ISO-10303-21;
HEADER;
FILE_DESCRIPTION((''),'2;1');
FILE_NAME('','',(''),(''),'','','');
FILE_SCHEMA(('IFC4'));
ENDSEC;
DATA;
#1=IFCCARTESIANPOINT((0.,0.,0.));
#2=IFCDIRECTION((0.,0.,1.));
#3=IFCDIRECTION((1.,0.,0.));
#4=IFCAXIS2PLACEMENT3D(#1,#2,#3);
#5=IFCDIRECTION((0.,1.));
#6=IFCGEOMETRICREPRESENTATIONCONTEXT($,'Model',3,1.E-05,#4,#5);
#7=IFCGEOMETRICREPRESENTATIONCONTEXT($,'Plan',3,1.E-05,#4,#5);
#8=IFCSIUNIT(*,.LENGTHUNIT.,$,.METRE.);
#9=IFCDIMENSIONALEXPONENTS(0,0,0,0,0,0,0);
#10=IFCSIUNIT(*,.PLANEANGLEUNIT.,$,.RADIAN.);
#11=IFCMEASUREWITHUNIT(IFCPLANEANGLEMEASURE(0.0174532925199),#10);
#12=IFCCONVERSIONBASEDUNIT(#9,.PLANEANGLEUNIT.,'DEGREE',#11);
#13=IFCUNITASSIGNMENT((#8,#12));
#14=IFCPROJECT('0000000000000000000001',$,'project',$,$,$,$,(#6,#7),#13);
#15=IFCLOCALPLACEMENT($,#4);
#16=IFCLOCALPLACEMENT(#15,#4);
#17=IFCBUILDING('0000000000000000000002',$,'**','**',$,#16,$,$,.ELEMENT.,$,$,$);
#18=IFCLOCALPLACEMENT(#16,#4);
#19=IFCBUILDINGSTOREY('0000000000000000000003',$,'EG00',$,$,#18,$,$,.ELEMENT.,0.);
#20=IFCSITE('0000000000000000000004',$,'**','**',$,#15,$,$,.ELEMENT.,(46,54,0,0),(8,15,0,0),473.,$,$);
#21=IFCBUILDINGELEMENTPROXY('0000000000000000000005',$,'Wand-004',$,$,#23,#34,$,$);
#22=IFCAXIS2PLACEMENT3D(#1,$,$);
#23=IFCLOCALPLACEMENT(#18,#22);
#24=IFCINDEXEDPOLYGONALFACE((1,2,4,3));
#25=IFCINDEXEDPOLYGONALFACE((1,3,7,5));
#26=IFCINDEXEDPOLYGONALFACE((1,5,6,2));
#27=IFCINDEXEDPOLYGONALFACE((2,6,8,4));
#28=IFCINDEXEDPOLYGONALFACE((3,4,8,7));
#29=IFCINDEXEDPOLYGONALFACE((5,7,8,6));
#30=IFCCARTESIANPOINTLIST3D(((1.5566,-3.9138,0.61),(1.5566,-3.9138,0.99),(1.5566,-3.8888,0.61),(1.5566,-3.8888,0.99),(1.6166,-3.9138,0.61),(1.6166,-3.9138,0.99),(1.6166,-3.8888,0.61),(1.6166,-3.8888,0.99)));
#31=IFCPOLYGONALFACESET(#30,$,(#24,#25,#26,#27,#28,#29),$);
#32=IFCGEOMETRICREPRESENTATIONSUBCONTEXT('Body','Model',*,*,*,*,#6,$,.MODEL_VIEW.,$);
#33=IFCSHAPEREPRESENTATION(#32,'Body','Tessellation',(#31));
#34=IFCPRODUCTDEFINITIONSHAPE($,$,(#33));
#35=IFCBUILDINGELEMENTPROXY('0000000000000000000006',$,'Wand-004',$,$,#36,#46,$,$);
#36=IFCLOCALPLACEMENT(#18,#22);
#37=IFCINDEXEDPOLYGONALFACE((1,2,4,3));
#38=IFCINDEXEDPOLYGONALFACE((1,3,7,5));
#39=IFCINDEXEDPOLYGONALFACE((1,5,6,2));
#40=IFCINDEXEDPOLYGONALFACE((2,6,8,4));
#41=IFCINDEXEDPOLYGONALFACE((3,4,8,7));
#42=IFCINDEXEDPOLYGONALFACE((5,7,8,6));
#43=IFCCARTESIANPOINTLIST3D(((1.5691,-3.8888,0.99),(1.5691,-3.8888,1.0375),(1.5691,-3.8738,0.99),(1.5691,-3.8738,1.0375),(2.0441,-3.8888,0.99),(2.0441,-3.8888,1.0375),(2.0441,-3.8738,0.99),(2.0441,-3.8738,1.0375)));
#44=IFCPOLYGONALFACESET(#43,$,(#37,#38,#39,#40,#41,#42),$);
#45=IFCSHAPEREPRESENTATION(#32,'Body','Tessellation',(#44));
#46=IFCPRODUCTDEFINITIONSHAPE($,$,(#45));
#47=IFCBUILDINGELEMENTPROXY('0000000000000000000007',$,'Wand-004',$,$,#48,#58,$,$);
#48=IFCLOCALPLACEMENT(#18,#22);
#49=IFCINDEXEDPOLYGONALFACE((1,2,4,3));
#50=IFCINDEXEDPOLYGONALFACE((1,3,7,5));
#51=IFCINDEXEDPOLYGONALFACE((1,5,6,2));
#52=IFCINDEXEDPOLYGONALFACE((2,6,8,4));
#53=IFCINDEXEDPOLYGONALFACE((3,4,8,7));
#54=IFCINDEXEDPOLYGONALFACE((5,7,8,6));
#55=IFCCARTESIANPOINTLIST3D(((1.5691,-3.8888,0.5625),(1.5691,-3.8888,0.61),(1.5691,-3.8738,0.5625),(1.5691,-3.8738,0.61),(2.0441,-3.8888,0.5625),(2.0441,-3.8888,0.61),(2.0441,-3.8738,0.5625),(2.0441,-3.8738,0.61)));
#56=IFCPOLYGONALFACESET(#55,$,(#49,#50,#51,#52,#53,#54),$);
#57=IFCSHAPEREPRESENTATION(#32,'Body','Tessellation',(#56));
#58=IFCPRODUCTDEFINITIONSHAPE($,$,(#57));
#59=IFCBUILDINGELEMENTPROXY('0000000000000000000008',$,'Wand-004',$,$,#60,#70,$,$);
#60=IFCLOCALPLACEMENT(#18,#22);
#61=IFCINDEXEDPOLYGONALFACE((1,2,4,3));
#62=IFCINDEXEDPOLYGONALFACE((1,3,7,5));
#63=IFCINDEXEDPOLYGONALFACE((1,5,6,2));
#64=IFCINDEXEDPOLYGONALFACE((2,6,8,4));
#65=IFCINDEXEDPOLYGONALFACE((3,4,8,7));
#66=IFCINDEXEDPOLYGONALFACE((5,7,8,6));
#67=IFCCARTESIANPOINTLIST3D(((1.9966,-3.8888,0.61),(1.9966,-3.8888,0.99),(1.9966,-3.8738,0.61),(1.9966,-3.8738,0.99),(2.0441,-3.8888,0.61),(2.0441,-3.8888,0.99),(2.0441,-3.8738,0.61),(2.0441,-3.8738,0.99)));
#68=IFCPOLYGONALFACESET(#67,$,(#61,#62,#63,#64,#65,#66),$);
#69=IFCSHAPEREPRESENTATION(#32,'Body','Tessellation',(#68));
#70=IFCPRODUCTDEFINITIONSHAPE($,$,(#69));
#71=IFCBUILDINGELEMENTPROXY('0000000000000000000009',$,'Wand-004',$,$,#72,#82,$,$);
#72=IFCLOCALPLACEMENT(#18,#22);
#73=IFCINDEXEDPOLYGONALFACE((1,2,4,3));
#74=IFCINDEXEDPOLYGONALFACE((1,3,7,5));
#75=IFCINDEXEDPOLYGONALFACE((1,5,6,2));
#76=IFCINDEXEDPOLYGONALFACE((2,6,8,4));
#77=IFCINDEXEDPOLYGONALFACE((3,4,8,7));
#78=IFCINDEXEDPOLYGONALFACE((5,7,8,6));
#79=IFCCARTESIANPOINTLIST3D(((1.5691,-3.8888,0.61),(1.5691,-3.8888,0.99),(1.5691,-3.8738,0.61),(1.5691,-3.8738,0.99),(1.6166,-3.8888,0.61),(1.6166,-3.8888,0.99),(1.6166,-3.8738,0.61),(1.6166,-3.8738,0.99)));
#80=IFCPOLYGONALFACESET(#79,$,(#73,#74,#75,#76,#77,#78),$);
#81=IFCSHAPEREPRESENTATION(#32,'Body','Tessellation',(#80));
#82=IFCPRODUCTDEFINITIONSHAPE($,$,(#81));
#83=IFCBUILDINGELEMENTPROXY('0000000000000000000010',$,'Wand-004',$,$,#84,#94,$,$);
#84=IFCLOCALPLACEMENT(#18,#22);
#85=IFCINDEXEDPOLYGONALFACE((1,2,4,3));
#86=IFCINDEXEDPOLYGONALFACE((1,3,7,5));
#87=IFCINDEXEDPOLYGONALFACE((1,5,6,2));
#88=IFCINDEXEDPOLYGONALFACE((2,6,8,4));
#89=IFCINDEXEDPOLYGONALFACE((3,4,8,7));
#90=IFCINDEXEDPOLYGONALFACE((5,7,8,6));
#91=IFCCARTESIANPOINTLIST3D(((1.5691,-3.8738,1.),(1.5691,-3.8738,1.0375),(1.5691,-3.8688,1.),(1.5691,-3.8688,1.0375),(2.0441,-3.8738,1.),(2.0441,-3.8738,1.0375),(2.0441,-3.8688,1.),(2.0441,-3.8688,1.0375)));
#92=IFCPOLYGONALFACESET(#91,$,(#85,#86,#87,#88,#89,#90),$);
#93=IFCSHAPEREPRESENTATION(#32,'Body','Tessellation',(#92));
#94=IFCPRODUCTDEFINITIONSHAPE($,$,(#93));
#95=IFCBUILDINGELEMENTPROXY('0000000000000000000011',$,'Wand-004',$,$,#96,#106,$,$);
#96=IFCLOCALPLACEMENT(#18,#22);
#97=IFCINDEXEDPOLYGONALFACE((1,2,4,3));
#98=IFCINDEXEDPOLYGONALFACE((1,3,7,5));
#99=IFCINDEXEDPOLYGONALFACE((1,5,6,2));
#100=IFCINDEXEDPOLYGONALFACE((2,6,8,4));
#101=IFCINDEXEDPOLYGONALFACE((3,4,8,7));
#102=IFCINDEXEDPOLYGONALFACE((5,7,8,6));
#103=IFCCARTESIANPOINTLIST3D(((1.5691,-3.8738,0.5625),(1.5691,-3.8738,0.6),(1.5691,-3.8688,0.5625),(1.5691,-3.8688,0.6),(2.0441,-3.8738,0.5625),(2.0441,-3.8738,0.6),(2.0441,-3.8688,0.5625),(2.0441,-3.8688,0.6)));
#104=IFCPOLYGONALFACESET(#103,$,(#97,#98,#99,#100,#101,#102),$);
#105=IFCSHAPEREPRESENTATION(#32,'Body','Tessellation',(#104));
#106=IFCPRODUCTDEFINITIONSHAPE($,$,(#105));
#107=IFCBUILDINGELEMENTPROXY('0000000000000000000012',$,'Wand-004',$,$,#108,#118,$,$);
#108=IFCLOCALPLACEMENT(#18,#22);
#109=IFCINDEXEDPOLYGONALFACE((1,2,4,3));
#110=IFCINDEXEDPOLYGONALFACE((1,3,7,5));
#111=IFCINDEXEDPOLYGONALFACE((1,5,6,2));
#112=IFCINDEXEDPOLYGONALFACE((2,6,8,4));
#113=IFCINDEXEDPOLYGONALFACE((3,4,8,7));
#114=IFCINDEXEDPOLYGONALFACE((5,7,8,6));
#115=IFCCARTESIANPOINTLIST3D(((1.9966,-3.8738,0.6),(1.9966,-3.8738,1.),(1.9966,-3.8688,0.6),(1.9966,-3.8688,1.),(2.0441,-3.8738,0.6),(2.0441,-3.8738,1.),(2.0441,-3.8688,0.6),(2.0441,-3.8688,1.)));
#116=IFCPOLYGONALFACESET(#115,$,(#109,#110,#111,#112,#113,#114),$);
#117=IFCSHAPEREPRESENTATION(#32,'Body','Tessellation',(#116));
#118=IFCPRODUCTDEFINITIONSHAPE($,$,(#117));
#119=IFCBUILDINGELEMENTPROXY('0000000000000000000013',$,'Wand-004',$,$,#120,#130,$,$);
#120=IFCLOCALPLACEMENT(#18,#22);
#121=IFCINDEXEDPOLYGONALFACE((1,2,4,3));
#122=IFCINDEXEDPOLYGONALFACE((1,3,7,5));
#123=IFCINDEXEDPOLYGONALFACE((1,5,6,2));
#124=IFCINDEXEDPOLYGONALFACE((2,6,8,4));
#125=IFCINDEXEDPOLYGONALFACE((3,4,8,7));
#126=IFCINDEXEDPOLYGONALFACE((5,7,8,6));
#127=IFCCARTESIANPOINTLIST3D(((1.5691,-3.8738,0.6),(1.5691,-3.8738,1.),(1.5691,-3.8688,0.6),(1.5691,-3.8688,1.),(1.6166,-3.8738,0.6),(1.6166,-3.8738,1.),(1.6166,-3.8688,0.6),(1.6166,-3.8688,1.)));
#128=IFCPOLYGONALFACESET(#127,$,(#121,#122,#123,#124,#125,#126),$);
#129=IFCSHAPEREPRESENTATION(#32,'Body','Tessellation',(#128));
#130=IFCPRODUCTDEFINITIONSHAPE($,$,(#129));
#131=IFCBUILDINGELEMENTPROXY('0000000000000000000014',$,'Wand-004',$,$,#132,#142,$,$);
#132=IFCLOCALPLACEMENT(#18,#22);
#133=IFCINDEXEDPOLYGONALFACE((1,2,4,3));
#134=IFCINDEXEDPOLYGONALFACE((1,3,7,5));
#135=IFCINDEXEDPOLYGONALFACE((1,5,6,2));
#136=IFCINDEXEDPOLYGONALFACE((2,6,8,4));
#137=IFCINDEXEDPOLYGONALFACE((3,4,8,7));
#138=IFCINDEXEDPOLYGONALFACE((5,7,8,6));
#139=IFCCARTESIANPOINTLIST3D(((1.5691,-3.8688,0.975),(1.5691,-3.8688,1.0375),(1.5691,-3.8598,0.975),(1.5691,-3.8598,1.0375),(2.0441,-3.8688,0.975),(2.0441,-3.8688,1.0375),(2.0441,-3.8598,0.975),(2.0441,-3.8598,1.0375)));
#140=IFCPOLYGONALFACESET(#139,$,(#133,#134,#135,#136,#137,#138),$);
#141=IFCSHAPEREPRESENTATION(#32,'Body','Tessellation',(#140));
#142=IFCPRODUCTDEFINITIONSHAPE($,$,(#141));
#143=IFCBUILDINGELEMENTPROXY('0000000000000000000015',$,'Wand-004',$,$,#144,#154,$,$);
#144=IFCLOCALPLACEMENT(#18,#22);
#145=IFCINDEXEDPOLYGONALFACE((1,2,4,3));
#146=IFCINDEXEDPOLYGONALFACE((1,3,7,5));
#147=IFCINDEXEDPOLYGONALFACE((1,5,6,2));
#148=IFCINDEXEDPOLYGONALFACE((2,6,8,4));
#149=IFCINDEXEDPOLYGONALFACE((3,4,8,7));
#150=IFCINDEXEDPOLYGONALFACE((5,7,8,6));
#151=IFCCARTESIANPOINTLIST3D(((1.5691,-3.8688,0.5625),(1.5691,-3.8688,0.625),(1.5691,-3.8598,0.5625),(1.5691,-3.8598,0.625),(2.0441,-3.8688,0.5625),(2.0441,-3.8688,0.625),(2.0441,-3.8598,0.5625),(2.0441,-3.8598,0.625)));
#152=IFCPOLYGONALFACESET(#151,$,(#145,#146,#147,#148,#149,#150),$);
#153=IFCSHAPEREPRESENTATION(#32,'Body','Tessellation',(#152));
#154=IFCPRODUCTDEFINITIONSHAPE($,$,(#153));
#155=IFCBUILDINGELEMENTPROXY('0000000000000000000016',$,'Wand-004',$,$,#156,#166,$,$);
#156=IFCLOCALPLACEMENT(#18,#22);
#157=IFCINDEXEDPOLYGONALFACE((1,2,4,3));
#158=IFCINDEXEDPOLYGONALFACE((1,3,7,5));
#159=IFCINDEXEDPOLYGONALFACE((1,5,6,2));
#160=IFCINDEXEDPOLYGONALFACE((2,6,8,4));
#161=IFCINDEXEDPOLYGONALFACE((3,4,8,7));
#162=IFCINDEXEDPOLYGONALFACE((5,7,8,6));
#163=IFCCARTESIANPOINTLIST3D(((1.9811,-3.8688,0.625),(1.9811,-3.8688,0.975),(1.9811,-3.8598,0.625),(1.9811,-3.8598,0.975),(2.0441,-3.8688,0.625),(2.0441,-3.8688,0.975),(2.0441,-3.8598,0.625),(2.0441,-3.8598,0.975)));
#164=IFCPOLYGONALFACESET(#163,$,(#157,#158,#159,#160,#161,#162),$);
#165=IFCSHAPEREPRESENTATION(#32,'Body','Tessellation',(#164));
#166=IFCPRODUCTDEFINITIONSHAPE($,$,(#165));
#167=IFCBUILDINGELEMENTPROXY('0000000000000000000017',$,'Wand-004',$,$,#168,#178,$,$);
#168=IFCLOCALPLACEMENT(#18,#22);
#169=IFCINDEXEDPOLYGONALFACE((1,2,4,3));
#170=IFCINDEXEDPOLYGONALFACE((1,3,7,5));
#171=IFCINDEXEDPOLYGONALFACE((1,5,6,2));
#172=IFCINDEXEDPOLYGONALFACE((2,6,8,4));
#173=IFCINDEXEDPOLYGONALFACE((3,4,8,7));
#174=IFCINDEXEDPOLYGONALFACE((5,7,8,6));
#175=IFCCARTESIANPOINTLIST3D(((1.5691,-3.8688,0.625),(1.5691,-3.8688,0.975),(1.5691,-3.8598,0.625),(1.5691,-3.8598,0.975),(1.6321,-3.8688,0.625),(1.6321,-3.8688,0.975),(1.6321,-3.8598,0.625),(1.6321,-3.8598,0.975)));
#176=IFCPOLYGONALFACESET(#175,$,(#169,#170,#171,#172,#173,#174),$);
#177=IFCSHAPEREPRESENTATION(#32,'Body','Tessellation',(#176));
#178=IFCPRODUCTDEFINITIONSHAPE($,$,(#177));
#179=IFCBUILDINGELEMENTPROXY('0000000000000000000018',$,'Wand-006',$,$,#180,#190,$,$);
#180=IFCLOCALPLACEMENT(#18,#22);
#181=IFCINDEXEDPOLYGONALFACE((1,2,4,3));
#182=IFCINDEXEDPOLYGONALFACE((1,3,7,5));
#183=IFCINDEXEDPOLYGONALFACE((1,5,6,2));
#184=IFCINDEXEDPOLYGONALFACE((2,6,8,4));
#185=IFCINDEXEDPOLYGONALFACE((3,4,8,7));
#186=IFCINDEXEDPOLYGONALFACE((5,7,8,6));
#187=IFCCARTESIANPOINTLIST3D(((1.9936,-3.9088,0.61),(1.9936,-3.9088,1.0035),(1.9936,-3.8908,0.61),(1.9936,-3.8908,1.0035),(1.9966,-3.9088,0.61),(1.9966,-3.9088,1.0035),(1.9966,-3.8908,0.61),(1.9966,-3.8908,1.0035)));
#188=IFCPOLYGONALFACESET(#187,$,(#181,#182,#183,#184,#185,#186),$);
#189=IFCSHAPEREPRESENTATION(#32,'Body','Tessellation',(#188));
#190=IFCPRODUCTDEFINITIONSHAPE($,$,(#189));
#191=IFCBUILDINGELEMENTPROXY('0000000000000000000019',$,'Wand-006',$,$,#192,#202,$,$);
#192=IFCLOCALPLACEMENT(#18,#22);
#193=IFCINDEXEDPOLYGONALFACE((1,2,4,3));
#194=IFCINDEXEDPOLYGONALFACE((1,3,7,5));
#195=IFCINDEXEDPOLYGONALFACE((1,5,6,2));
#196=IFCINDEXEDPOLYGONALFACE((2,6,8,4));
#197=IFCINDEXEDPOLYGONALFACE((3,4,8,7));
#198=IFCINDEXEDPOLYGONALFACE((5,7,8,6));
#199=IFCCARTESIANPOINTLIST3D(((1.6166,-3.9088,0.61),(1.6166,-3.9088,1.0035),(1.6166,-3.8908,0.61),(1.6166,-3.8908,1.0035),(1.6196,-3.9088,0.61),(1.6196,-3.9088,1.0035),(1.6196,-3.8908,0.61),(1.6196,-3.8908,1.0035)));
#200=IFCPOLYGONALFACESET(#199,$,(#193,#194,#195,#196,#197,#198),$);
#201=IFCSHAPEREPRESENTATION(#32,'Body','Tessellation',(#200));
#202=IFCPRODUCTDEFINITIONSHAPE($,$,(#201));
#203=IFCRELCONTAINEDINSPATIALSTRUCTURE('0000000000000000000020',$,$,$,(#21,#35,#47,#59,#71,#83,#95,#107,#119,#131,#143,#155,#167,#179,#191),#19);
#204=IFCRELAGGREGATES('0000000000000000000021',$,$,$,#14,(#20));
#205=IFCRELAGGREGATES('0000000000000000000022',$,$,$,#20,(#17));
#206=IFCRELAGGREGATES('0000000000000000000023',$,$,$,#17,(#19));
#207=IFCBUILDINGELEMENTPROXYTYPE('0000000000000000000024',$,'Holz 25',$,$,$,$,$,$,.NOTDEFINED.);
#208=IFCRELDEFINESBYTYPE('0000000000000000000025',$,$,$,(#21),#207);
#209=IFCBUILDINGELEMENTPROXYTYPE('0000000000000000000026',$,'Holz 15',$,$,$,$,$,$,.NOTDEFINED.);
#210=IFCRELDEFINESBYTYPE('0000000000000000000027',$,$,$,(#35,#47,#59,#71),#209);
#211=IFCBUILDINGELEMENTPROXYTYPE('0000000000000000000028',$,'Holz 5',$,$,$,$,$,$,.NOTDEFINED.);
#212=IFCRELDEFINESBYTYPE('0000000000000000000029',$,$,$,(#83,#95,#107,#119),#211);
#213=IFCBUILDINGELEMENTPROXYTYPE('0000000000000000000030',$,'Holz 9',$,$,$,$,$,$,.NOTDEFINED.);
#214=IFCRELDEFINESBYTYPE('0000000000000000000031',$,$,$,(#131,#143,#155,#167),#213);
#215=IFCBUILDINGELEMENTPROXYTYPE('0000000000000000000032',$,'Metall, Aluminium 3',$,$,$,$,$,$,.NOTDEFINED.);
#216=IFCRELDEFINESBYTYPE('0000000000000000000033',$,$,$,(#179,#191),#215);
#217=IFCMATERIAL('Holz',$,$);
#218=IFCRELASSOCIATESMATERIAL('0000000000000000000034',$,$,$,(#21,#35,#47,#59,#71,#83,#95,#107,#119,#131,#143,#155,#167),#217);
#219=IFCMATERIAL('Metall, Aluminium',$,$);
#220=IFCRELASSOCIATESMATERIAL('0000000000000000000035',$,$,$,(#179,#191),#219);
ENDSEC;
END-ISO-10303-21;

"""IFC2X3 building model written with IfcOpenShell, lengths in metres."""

from ifc_helpers import new_model, entity, si_unit, converted_unit, direction, frame, origin_with_axes, place, context, subcontext, project, spatial, polyline, outline, extrude, material, type_object, element, save


model = new_model("IFC2X3")

# Units and contexts
model_context = context("Model", 3, precision=1e-05, world=origin_with_axes(), true_north=direction((0.0, 1.0)))
plan_context = context("Plan", 3, precision=1e-05, world=origin_with_axes(), true_north=direction((0.0, 1.0)))
body_context = subcontext(model_context, "Body", "Model", "MODEL_VIEW")
ifc_project = project(units=[si_unit("LENGTHUNIT", "METRE"), converted_unit("PLANEANGLEUNIT", "DEGREE", entity("IfcPlaneAngleMeasure", 0.0174532925199), si_unit("PLANEANGLEUNIT", "RADIAN"), dimensions=[0, 0, 0, 0, 0, 0, 0])], contexts=[model_context, plan_context])

# Site, building, storey
site_placement = place(None, origin_with_axes())
site = spatial("IfcSite", under=ifc_project, at=site_placement, Name="**", Description="**", CompositionType="ELEMENT", RefLatitude=(46, 54, 0, 0), RefLongitude=(8, 15, 0, 0), RefElevation=473.0)
building_placement = place(site_placement, origin_with_axes())
building = spatial("IfcBuilding", under=site, at=building_placement, Name="**", Description="**", CompositionType="ELEMENT")
storey_placement = place(building_placement, origin_with_axes())
storey = spatial("IfcBuildingStorey", under=building, at=storey_placement, Name="EG00", CompositionType="ELEMENT", Elevation=0.0)

# Shared definitions
ifc_material_1 = material(Name="Holz")

# Building element proxies
building_element_proxy_type_1 = type_object("IfcBuildingElementProxyType", Name="Holz 25", PredefinedType="NOTDEFINED")
for number, where, z_axis, x_axis, name in (
    (1, (1.5566, -3.9138, 0.61), (0.0, 0.0, 1.0), (1.0, 0.0, 0.0), "Wand-004"),
):
    element("IfcBuildingElementProxy", number, at=place(storey_placement, frame(where, z_axis=z_axis, x_axis=x_axis)), inside=storey, type_object=building_element_proxy_type_1, material=ifc_material_1, Name=name, context=body_context, shape_type="SweptSolid", body=[
        extrude(outline(polyline([(0.0, 0.0), (0.06, 0.0), (0.06, 0.025), (0.0, 0.025), (0.0, 0.0)])), origin_with_axes(), (0.0, 0.0, 1.0), 0.38),
    ])
building_element_proxy_type_2 = type_object("IfcBuildingElementProxyType", Name="Holz 15", PredefinedType="NOTDEFINED")
for number, where, z_axis, x_axis, name in (
    (2, (2.0441, -3.8738, 0.99), (0.0, 0.0, 1.0), (-1.0, 0.0, 0.0), "Wand-004"),
    (3, (2.0441, -3.8738, 0.5625), (0.0, 0.0, 1.0), (-1.0, 0.0, 0.0), "Wand-004"),
):
    element("IfcBuildingElementProxy", number, at=place(storey_placement, frame(where, z_axis=z_axis, x_axis=x_axis)), inside=storey, type_object=building_element_proxy_type_2, material=ifc_material_1, Name=name, context=body_context, shape_type="SweptSolid", body=[
        extrude(outline(polyline([(0.0, 0.0), (0.475, 0.0), (0.475, 0.015), (0.0, 0.015), (0.0, 0.0)])), origin_with_axes(), (0.0, 0.0, 1.0), 0.0475),
    ])
for number, where, z_axis, x_axis, name in (
    (4, (1.9966, -3.8888, 0.61), (0.0, 0.0, 1.0), (1.0, 0.0, 0.0), "Wand-004"),
    (5, (1.5691, -3.8888, 0.61), (0.0, 0.0, 1.0), (1.0, 0.0, 0.0), "Wand-004"),
):
    element("IfcBuildingElementProxy", number, at=place(storey_placement, frame(where, z_axis=z_axis, x_axis=x_axis)), inside=storey, type_object=building_element_proxy_type_2, material=ifc_material_1, Name=name, context=body_context, shape_type="SweptSolid", body=[
        extrude(outline(polyline([(0.0, 0.0), (0.0475, 0.0), (0.0475, 0.015), (0.0, 0.015), (0.0, 0.0)])), origin_with_axes(), (0.0, 0.0, 1.0), 0.38),
    ])
building_element_proxy_type_3 = type_object("IfcBuildingElementProxyType", Name="Holz 5", PredefinedType="NOTDEFINED")
for number, where, z_axis, x_axis, name in (
    (6, (2.0441, -3.8738, 1.0), (0.0, 0.0, 1.0), (-1.0, 0.0, 0.0), "Wand-004"),
    (7, (2.0441, -3.8738, 0.5625), (0.0, 0.0, 1.0), (-1.0, 0.0, 0.0), "Wand-004"),
):
    element("IfcBuildingElementProxy", number, at=place(storey_placement, frame(where, z_axis=z_axis, x_axis=x_axis)), inside=storey, type_object=building_element_proxy_type_3, material=ifc_material_1, Name=name, context=body_context, shape_type="SweptSolid", body=[
        extrude(outline(polyline([(0.0, -0.005), (0.475, -0.005), (0.475, 0.0), (0.0, 0.0), (0.0, -0.005)])), origin_with_axes(), (0.0, 0.0, 1.0), 0.0375),
    ])
for number, where, z_axis, x_axis, name in (
    (8, (1.9966, -3.8738, 0.6), (0.0, 0.0, 1.0), (1.0, 0.0, 0.0), "Wand-004"),
    (9, (1.5691, -3.8738, 0.6), (0.0, 0.0, 1.0), (1.0, 0.0, 0.0), "Wand-004"),
):
    element("IfcBuildingElementProxy", number, at=place(storey_placement, frame(where, z_axis=z_axis, x_axis=x_axis)), inside=storey, type_object=building_element_proxy_type_3, material=ifc_material_1, Name=name, context=body_context, shape_type="SweptSolid", body=[
        extrude(outline(polyline([(0.0, 0.0), (0.0475, 0.0), (0.0475, 0.005), (0.0, 0.005), (0.0, 0.0)])), origin_with_axes(), (0.0, 0.0, 1.0), 0.4),
    ])
building_element_proxy_type_4 = type_object("IfcBuildingElementProxyType", Name="Holz 9", PredefinedType="NOTDEFINED")
for number, where, z_axis, x_axis, name in (
    (10, (2.0441, -3.8688, 0.975), (0.0, 0.0, 1.0), (-1.0, 0.0, 0.0), "Wand-004"),
    (11, (2.0441, -3.8688, 0.5625), (0.0, 0.0, 1.0), (-1.0, 0.0, 0.0), "Wand-004"),
):
    element("IfcBuildingElementProxy", number, at=place(storey_placement, frame(where, z_axis=z_axis, x_axis=x_axis)), inside=storey, type_object=building_element_proxy_type_4, material=ifc_material_1, Name=name, context=body_context, shape_type="SweptSolid", body=[
        extrude(outline(polyline([(0.0, -0.009), (0.475, -0.009), (0.475, 0.0), (0.0, 0.0), (0.0, -0.009)])), origin_with_axes(), (0.0, 0.0, 1.0), 0.0625),
    ])
for number, where, z_axis, x_axis, name in (
    (12, (1.9811, -3.8688, 0.625), (0.0, 0.0, 1.0), (1.0, 0.0, 0.0), "Wand-004"),
    (13, (1.5691, -3.8688, 0.625), (0.0, 0.0, 1.0), (1.0, 0.0, 0.0), "Wand-004"),
):
    element("IfcBuildingElementProxy", number, at=place(storey_placement, frame(where, z_axis=z_axis, x_axis=x_axis)), inside=storey, type_object=building_element_proxy_type_4, material=ifc_material_1, Name=name, context=body_context, shape_type="SweptSolid", body=[
        extrude(outline(polyline([(0.0, 0.0), (0.063, 0.0), (0.063, 0.009), (0.0, 0.009), (0.0, 0.0)])), origin_with_axes(), (0.0, 0.0, 1.0), 0.35),
    ])
ifc_material_2 = material(Name="Metall, Aluminium")
building_element_proxy_type_5 = type_object("IfcBuildingElementProxyType", Name="Metall, Aluminium 3", PredefinedType="NOTDEFINED")
proxy_1_placement = place(storey_placement, frame((1.9966, -3.8908, 0.61), z_axis=(0.0, 0.0, 1.0), x_axis=(0.0, -1.0, 0.0)))
element("IfcBuildingElementProxy", 14, at=proxy_1_placement, inside=storey, type_object=building_element_proxy_type_5, material=ifc_material_2, Name="Wand-006", context=body_context, shape_type="SweptSolid", body=[
    extrude(outline(polyline([(0.0, -0.003), (0.018, -0.003), (0.018, 0.0), (0.0, 0.0), (0.0, -0.003)])), origin_with_axes(), (0.0, 0.0, 1.0), 0.3935),
])
proxy_2_placement = place(storey_placement, frame((1.6166, -3.8908, 0.61), z_axis=(0.0, 0.0, 1.0), x_axis=(0.0, -1.0, 0.0)))
element("IfcBuildingElementProxy", 15, at=proxy_2_placement, inside=storey, type_object=building_element_proxy_type_5, material=ifc_material_2, Name="Wand-006", context=body_context, shape_type="SweptSolid", body=[
    extrude(outline(polyline([(0.0, 0.0), (0.018, 0.0), (0.018, 0.003), (0.0, 0.003), (0.0, 0.0)])), origin_with_axes(), (0.0, 0.0, 1.0), 0.3935),
])

save(model, "model.ifc")
